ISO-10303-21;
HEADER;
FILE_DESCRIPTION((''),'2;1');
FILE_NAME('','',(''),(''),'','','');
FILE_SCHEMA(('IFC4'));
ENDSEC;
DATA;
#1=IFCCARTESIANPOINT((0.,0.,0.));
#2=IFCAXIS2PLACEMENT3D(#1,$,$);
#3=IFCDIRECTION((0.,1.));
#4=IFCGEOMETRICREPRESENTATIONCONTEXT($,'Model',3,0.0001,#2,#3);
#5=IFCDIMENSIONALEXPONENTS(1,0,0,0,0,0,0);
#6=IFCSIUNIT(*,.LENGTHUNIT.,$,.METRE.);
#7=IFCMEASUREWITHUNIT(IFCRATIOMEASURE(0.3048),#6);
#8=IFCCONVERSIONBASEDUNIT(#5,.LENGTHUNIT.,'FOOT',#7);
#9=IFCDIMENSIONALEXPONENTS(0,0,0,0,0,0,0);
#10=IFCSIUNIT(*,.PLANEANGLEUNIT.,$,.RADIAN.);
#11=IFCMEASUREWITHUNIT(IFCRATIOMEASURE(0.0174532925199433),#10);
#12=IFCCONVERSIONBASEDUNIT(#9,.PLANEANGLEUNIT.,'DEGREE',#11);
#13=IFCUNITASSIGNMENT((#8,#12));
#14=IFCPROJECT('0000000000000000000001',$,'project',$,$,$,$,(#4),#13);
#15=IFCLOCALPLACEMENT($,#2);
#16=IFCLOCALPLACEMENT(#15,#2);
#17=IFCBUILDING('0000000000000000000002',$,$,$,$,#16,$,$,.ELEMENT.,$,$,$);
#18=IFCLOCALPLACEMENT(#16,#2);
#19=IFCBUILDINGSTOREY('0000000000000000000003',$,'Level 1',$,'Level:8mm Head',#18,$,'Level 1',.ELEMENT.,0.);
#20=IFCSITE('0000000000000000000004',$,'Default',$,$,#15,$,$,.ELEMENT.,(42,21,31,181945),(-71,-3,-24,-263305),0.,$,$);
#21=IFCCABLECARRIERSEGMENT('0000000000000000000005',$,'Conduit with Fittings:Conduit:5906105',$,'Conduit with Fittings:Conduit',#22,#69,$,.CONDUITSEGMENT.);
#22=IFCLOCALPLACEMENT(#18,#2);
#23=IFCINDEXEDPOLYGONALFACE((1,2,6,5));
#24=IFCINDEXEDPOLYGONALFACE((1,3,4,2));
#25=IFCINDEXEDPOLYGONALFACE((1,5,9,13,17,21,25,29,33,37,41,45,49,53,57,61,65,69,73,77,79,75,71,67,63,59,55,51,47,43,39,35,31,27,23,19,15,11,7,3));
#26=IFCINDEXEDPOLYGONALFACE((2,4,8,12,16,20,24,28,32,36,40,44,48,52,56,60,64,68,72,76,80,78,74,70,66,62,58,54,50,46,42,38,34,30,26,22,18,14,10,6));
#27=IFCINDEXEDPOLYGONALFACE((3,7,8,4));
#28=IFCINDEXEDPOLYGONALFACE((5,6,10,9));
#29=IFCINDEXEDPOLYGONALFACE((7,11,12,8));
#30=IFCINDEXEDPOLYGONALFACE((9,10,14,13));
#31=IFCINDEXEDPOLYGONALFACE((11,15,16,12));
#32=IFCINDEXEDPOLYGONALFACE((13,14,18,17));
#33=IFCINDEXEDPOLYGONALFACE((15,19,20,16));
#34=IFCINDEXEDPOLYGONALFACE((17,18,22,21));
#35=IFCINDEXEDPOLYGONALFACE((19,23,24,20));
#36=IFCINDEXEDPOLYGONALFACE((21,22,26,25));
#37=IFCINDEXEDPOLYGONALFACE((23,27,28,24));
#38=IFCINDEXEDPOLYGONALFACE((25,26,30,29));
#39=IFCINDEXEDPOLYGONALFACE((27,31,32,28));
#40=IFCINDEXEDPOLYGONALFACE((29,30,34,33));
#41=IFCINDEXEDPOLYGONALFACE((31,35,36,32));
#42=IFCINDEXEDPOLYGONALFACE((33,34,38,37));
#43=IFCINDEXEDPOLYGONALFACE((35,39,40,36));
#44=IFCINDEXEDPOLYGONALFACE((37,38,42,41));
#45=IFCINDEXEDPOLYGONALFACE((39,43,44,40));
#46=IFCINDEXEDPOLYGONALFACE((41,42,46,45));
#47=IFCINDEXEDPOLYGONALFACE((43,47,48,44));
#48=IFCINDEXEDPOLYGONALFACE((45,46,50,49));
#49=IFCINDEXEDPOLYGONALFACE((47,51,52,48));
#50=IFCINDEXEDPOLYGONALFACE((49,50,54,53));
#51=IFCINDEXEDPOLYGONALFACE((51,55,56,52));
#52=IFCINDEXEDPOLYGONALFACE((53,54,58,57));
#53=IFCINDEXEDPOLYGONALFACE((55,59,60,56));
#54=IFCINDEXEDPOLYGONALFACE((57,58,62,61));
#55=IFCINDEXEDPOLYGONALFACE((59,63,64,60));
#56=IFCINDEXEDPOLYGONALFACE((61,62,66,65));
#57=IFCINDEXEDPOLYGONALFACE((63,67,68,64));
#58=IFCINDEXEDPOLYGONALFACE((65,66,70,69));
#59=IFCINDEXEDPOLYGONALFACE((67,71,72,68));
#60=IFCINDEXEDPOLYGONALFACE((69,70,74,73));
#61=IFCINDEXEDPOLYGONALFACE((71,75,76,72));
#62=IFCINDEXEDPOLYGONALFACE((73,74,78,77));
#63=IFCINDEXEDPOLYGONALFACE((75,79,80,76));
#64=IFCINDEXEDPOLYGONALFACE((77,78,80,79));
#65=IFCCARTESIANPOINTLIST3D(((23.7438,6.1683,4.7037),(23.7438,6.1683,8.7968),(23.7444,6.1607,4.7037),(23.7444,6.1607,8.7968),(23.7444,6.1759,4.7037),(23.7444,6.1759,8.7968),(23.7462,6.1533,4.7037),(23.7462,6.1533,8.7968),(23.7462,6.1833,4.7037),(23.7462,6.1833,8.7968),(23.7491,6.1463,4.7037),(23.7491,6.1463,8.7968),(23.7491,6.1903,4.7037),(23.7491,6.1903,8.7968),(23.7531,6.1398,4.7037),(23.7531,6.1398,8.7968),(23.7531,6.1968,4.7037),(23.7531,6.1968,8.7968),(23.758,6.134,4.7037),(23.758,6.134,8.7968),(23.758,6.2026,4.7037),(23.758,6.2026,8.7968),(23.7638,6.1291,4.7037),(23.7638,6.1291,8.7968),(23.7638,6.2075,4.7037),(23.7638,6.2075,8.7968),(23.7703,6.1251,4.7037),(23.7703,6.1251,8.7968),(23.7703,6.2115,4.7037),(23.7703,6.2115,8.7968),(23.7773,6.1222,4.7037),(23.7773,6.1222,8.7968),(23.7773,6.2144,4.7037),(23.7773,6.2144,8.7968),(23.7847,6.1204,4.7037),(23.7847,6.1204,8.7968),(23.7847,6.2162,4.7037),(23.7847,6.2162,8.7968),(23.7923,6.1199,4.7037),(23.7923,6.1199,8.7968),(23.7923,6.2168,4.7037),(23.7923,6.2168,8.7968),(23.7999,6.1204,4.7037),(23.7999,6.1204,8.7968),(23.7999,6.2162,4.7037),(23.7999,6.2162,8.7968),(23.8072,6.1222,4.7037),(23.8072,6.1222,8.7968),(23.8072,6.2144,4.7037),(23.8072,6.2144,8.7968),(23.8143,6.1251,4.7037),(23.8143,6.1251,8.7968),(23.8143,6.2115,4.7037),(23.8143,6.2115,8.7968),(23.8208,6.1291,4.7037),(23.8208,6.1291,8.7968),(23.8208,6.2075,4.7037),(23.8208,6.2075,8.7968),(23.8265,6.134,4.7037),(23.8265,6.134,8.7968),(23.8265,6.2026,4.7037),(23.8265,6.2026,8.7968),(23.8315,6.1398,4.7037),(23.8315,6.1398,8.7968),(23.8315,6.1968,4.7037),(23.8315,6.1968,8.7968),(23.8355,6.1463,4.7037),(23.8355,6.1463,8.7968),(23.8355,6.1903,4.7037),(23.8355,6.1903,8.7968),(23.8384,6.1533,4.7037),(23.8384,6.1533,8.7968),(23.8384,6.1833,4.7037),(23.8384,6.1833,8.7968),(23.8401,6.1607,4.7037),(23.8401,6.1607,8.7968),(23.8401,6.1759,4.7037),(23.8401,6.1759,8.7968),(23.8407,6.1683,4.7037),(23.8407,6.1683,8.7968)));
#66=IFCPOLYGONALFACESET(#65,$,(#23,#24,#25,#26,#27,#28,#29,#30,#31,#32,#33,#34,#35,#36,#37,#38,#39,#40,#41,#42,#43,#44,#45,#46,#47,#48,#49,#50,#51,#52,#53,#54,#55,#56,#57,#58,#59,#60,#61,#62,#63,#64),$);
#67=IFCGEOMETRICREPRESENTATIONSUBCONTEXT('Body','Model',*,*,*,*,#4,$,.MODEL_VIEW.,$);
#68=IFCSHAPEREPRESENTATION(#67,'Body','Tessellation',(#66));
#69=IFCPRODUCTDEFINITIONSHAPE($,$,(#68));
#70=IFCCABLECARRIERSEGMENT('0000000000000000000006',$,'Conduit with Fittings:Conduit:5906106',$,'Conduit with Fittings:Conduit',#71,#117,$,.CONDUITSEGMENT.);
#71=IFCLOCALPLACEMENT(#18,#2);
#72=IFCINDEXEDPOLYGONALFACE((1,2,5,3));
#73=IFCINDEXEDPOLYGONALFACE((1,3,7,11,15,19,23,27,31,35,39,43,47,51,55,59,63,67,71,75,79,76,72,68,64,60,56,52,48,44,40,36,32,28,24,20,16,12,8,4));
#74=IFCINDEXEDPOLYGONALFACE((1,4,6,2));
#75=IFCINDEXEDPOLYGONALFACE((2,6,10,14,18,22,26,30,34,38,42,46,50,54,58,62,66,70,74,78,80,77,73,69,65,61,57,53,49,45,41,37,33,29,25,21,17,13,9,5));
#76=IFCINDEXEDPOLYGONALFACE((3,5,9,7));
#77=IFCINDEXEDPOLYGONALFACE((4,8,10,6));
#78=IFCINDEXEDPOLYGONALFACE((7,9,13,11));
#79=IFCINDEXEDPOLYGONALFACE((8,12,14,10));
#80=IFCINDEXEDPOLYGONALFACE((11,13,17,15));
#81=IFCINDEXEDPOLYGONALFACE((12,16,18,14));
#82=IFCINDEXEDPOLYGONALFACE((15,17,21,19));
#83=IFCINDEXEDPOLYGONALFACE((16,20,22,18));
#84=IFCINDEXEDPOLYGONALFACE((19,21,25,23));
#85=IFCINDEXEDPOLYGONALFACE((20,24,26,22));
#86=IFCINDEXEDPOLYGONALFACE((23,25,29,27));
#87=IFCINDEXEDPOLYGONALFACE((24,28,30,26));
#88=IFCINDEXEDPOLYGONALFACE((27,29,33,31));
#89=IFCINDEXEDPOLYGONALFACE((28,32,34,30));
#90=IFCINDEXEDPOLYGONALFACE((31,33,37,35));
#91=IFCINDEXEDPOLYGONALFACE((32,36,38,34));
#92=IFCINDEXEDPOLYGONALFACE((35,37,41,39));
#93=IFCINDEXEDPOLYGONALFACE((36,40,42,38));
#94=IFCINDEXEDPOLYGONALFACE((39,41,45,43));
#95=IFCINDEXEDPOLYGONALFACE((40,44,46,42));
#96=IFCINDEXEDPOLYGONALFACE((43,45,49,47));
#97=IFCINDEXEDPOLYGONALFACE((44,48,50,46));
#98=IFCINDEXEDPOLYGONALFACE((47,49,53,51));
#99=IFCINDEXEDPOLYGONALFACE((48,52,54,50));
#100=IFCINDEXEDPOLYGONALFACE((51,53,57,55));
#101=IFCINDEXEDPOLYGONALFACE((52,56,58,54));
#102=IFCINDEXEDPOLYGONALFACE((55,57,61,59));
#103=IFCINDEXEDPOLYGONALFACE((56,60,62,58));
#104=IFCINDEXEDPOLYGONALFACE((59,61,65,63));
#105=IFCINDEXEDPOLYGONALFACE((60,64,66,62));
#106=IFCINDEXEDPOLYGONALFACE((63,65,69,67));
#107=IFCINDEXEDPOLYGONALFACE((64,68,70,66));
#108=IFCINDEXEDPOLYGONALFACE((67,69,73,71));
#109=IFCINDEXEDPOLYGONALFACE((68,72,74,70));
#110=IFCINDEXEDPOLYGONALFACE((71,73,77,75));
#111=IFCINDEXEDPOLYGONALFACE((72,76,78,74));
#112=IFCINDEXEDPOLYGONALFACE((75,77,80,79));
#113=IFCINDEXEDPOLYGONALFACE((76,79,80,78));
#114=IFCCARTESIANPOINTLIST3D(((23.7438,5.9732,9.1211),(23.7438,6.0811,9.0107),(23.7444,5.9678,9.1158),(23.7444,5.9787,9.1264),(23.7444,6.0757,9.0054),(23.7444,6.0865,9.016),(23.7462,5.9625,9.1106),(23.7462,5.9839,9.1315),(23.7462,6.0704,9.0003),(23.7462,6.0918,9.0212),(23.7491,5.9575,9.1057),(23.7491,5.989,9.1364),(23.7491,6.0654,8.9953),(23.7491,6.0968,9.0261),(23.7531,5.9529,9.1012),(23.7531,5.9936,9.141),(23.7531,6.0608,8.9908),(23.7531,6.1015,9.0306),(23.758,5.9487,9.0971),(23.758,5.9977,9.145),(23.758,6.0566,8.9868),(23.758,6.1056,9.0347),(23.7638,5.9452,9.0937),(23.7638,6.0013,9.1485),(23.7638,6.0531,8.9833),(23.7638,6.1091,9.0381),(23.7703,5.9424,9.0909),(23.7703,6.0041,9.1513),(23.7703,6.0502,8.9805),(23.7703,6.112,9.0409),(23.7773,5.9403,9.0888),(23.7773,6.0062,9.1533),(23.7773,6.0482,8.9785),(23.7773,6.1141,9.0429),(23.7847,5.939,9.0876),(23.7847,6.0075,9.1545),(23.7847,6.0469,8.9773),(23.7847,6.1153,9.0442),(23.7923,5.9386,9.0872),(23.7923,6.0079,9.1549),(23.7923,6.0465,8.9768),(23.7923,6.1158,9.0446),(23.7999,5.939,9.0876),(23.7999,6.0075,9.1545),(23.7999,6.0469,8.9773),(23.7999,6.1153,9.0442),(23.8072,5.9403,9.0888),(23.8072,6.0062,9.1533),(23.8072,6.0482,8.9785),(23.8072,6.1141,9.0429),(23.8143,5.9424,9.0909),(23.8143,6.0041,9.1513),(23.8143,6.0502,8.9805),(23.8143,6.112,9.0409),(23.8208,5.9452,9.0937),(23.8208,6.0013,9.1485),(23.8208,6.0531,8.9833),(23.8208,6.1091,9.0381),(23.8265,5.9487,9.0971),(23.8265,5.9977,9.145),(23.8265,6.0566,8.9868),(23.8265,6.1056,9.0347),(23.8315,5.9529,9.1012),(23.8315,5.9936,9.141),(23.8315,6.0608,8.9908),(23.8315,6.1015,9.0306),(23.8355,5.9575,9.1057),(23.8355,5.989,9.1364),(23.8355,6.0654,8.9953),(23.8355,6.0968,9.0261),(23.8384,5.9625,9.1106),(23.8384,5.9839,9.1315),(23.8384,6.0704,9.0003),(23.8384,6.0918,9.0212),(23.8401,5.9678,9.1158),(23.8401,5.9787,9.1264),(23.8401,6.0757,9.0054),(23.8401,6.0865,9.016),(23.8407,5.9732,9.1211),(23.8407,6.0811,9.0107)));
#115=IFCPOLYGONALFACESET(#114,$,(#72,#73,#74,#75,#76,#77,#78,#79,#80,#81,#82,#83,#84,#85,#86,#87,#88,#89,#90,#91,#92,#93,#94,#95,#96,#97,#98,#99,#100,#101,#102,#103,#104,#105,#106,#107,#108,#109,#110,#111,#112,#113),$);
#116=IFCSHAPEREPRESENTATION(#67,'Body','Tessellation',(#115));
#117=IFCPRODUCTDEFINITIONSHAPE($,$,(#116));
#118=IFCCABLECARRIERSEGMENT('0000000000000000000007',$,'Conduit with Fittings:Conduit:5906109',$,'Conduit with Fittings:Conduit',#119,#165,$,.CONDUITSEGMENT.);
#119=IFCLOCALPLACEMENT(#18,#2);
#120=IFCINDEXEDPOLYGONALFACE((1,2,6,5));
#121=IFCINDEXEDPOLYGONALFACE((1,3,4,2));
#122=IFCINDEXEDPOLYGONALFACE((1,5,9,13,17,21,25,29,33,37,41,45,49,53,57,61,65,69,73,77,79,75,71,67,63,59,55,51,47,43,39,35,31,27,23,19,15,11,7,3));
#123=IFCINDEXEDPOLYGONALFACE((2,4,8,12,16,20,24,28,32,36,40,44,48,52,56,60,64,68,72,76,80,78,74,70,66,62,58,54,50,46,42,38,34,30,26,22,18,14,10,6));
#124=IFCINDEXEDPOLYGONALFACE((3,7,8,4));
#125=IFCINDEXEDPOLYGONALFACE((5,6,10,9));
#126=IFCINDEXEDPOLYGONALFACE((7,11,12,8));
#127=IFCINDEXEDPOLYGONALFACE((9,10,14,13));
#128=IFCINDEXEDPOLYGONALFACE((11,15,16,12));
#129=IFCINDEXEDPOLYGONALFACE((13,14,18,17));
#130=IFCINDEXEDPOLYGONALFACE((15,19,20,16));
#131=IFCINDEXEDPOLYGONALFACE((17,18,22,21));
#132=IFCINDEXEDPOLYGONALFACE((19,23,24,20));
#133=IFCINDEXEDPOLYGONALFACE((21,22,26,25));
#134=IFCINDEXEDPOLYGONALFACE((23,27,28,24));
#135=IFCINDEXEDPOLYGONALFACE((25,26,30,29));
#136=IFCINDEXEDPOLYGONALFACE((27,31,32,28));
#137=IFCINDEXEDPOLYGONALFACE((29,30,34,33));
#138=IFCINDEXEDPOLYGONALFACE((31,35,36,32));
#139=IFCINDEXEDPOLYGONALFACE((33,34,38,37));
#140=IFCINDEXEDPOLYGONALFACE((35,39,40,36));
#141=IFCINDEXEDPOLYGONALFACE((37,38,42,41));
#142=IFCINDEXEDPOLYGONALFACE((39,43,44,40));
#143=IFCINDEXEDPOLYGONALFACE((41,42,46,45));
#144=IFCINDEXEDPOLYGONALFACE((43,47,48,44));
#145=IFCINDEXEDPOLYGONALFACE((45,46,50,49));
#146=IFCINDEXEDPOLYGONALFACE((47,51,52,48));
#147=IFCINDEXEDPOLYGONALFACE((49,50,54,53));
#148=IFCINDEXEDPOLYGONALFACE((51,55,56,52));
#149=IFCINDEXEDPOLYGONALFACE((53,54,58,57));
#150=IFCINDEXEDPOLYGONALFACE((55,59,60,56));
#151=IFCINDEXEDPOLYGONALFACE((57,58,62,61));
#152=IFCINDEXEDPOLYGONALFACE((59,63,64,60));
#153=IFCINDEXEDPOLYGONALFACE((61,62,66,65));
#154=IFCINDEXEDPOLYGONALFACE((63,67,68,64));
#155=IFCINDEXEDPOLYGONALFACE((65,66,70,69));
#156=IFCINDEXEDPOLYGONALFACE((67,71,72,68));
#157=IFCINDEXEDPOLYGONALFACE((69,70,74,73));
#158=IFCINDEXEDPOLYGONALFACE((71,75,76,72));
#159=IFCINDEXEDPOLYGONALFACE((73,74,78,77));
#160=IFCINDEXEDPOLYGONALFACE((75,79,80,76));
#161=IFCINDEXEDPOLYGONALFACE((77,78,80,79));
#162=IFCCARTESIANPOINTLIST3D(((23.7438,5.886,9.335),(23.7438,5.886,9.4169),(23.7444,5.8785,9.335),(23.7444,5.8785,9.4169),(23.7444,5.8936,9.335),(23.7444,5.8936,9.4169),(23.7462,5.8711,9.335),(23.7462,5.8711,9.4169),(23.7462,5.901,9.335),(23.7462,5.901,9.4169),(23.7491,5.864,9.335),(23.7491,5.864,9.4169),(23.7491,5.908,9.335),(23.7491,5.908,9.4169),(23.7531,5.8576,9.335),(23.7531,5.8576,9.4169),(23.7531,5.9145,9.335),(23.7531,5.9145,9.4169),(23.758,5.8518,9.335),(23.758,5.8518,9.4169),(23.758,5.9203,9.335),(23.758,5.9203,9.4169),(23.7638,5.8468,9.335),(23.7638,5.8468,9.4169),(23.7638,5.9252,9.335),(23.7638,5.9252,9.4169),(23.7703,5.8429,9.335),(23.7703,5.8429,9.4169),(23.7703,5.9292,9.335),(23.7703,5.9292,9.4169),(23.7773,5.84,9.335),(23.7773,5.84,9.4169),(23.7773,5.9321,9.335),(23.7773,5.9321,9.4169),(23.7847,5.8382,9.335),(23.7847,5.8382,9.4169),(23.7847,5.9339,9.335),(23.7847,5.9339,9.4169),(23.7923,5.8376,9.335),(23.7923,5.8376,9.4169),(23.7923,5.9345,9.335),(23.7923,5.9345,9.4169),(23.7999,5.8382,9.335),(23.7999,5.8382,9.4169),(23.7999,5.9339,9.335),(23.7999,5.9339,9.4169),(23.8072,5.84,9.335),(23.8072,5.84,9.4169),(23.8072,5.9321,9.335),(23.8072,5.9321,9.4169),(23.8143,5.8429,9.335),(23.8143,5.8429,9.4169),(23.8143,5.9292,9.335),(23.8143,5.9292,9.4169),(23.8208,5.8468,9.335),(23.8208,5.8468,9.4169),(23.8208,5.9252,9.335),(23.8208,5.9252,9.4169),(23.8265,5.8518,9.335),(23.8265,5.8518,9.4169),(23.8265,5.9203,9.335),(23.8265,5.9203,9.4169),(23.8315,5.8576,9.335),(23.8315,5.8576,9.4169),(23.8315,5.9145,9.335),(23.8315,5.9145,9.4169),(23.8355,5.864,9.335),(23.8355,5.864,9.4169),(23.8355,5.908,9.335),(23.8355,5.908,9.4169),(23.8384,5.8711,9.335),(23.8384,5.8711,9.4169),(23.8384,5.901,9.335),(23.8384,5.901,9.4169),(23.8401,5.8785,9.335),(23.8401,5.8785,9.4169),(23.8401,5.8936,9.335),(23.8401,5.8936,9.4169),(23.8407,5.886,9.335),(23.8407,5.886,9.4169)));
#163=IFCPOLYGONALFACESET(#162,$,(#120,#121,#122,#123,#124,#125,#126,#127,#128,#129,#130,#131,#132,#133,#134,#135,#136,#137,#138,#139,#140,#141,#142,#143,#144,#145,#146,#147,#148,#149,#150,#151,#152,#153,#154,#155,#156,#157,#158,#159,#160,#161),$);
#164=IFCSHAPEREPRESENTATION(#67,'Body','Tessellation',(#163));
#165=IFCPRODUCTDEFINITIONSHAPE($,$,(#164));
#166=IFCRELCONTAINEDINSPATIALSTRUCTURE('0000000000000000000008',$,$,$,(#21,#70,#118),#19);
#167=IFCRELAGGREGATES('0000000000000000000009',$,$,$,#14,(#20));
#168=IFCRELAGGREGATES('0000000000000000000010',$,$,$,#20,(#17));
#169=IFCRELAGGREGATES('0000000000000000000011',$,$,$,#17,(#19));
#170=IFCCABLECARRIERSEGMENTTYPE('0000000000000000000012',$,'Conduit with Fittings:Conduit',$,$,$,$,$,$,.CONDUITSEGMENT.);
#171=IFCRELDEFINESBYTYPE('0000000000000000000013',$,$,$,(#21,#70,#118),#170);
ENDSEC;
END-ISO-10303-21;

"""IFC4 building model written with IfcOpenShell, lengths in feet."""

from ifc_helpers import new_model, entity, si_unit, converted_unit, direction, frame, origin, place, context, subcontext, project, spatial, indexed_curve, outline, extrude, type_object, element, save


model = new_model("IFC4")

# Units and contexts
model_context = context("Model", 3, precision=0.0001, world=origin(), true_north=direction((0.0, 1.0)))
body_context = subcontext(model_context, "Body", "Model", "MODEL_VIEW")
ifc_project = project(units=[converted_unit("LENGTHUNIT", "FOOT", entity("IfcRatioMeasure", 0.3048), si_unit("LENGTHUNIT", "METRE"), dimensions=[1, 0, 0, 0, 0, 0, 0]), converted_unit("PLANEANGLEUNIT", "DEGREE", entity("IfcRatioMeasure", 0.0174532925199433), si_unit("PLANEANGLEUNIT", "RADIAN"), dimensions=[0, 0, 0, 0, 0, 0, 0])], contexts=[model_context])

# Site, building, storey
site_placement = place(None, origin())
site = spatial("IfcSite", under=ifc_project, at=site_placement, Name="Default", CompositionType="ELEMENT", RefLatitude=(42, 21, 31, 181945), RefLongitude=(-71, -3, -24, -263305), RefElevation=0.0)
building_placement = place(site_placement, origin())
building = spatial("IfcBuilding", under=site, at=building_placement, CompositionType="ELEMENT")
storey_placement = place(building_placement, origin())
storey = spatial("IfcBuildingStorey", under=building, at=storey_placement, Name="Level 1", ObjectType="Level:8mm Head", LongName="Level 1", CompositionType="ELEMENT", Elevation=0.0)

# Cable carrier segments
cable_carrier_segment_type_1 = type_object("IfcCableCarrierSegmentType", Name="Conduit with Fittings:Conduit", PredefinedType="CONDUITSEGMENT")
cable_carrier_segment_1_placement = place(storey_placement, origin())
element("IfcCableCarrierSegment", 1, at=cable_carrier_segment_1_placement, inside=storey, type_object=cable_carrier_segment_type_1, Name="Conduit with Fittings:Conduit:5906105", ObjectType="Conduit with Fittings:Conduit", PredefinedType="CONDUITSEGMENT", context=body_context, shape_type="SweptSolid", body=[
    extrude(outline(indexed_curve([(0.0485, 0.0), (0.0479, 0.0076), (0.0461, 0.015), (0.0432, 0.022), (0.0392, 0.0285), (0.0343, 0.0343), (0.0285, 0.0392), (0.022, 0.0432), (0.015, 0.0461), (0.0076, 0.0479), (0.0, 0.0485), (-0.0076, 0.0479), (-0.015, 0.0461), (-0.022, 0.0432), (-0.0285, 0.0392), (-0.0343, 0.0343), (-0.0392, 0.0285), (-0.0432, 0.022), (-0.0461, 0.015), (-0.0479, 0.0076), (-0.0485, 0.0), (-0.0479, -0.0076), (-0.0461, -0.015), (-0.0432, -0.022), (-0.0392, -0.0285), (-0.0343, -0.0343), (-0.0285, -0.0392), (-0.022, -0.0432), (-0.015, -0.0461), (-0.0076, -0.0479), (0.0, -0.0485), (0.0076, -0.0479), (0.015, -0.0461), (0.022, -0.0432), (0.0285, -0.0392), (0.0343, -0.0343), (0.0392, -0.0285), (0.0432, -0.022), (0.0461, -0.015), (0.0479, -0.0076), (0.0485, 0.0)], self_intersect=False)), frame((23.7923, 6.1683, 4.7037)), (0.0, 0.0, 1.0), 4.0931),
])
cable_carrier_segment_2_placement = place(storey_placement, origin())
element("IfcCableCarrierSegment", 2, at=cable_carrier_segment_2_placement, inside=storey, type_object=cable_carrier_segment_type_1, Name="Conduit with Fittings:Conduit:5906106", ObjectType="Conduit with Fittings:Conduit", PredefinedType="CONDUITSEGMENT", context=body_context, shape_type="SweptSolid", body=[
    extrude(outline(indexed_curve([(0.0485, 0.0), (0.0479, 0.0076), (0.0461, 0.015), (0.0432, 0.022), (0.0392, 0.0285), (0.0343, 0.0343), (0.0285, 0.0392), (0.022, 0.0432), (0.015, 0.0461), (0.0076, 0.0479), (0.0, 0.0485), (-0.0076, 0.0479), (-0.015, 0.0461), (-0.022, 0.0432), (-0.0285, 0.0392), (-0.0343, 0.0343), (-0.0392, 0.0285), (-0.0432, 0.022), (-0.0461, 0.015), (-0.0479, 0.0076), (-0.0485, 0.0), (-0.0479, -0.0076), (-0.0461, -0.015), (-0.0432, -0.022), (-0.0392, -0.0285), (-0.0343, -0.0343), (-0.0285, -0.0392), (-0.022, -0.0432), (-0.015, -0.0461), (-0.0076, -0.0479), (0.0, -0.0485), (0.0076, -0.0479), (0.015, -0.0461), (0.022, -0.0432), (0.0285, -0.0392), (0.0343, -0.0343), (0.0392, -0.0285), (0.0432, -0.022), (0.0461, -0.015), (0.0479, -0.0076), (0.0485, 0.0)], self_intersect=False)), frame((23.7923, 5.9732, 9.1211), z_axis=(0.0, 0.699077, -0.715046), x_axis=(-1.0, 0.0, 0.0)), (0.0, 0.0, 1.0), 0.1543),
])
cable_carrier_segment_3_placement = place(storey_placement, origin())
element("IfcCableCarrierSegment", 3, at=cable_carrier_segment_3_placement, inside=storey, type_object=cable_carrier_segment_type_1, Name="Conduit with Fittings:Conduit:5906109", ObjectType="Conduit with Fittings:Conduit", PredefinedType="CONDUITSEGMENT", context=body_context, shape_type="SweptSolid", body=[
    extrude(outline(indexed_curve([(0.0485, 0.0), (0.0479, 0.0076), (0.0461, 0.015), (0.0432, 0.022), (0.0392, 0.0285), (0.0343, 0.0343), (0.0285, 0.0392), (0.022, 0.0432), (0.015, 0.0461), (0.0076, 0.0479), (0.0, 0.0485), (-0.0076, 0.0479), (-0.015, 0.0461), (-0.022, 0.0432), (-0.0285, 0.0392), (-0.0343, 0.0343), (-0.0392, 0.0285), (-0.0432, 0.022), (-0.0461, 0.015), (-0.0479, 0.0076), (-0.0485, 0.0), (-0.0479, -0.0076), (-0.0461, -0.015), (-0.0432, -0.022), (-0.0392, -0.0285), (-0.0343, -0.0343), (-0.0285, -0.0392), (-0.022, -0.0432), (-0.015, -0.0461), (-0.0076, -0.0479), (0.0, -0.0485), (0.0076, -0.0479), (0.015, -0.0461), (0.022, -0.0432), (0.0285, -0.0392), (0.0343, -0.0343), (0.0392, -0.0285), (0.0432, -0.022), (0.0461, -0.015), (0.0479, -0.0076), (0.0485, 0.0)], self_intersect=False)), frame((23.7923, 5.886, 9.335), z_axis=(0.0, 0.0, 1.0), x_axis=(-1.0, 0.0, 0.0)), (0.0, 0.0, 1.0), 0.082),
])

save(model, "model.ifc")
